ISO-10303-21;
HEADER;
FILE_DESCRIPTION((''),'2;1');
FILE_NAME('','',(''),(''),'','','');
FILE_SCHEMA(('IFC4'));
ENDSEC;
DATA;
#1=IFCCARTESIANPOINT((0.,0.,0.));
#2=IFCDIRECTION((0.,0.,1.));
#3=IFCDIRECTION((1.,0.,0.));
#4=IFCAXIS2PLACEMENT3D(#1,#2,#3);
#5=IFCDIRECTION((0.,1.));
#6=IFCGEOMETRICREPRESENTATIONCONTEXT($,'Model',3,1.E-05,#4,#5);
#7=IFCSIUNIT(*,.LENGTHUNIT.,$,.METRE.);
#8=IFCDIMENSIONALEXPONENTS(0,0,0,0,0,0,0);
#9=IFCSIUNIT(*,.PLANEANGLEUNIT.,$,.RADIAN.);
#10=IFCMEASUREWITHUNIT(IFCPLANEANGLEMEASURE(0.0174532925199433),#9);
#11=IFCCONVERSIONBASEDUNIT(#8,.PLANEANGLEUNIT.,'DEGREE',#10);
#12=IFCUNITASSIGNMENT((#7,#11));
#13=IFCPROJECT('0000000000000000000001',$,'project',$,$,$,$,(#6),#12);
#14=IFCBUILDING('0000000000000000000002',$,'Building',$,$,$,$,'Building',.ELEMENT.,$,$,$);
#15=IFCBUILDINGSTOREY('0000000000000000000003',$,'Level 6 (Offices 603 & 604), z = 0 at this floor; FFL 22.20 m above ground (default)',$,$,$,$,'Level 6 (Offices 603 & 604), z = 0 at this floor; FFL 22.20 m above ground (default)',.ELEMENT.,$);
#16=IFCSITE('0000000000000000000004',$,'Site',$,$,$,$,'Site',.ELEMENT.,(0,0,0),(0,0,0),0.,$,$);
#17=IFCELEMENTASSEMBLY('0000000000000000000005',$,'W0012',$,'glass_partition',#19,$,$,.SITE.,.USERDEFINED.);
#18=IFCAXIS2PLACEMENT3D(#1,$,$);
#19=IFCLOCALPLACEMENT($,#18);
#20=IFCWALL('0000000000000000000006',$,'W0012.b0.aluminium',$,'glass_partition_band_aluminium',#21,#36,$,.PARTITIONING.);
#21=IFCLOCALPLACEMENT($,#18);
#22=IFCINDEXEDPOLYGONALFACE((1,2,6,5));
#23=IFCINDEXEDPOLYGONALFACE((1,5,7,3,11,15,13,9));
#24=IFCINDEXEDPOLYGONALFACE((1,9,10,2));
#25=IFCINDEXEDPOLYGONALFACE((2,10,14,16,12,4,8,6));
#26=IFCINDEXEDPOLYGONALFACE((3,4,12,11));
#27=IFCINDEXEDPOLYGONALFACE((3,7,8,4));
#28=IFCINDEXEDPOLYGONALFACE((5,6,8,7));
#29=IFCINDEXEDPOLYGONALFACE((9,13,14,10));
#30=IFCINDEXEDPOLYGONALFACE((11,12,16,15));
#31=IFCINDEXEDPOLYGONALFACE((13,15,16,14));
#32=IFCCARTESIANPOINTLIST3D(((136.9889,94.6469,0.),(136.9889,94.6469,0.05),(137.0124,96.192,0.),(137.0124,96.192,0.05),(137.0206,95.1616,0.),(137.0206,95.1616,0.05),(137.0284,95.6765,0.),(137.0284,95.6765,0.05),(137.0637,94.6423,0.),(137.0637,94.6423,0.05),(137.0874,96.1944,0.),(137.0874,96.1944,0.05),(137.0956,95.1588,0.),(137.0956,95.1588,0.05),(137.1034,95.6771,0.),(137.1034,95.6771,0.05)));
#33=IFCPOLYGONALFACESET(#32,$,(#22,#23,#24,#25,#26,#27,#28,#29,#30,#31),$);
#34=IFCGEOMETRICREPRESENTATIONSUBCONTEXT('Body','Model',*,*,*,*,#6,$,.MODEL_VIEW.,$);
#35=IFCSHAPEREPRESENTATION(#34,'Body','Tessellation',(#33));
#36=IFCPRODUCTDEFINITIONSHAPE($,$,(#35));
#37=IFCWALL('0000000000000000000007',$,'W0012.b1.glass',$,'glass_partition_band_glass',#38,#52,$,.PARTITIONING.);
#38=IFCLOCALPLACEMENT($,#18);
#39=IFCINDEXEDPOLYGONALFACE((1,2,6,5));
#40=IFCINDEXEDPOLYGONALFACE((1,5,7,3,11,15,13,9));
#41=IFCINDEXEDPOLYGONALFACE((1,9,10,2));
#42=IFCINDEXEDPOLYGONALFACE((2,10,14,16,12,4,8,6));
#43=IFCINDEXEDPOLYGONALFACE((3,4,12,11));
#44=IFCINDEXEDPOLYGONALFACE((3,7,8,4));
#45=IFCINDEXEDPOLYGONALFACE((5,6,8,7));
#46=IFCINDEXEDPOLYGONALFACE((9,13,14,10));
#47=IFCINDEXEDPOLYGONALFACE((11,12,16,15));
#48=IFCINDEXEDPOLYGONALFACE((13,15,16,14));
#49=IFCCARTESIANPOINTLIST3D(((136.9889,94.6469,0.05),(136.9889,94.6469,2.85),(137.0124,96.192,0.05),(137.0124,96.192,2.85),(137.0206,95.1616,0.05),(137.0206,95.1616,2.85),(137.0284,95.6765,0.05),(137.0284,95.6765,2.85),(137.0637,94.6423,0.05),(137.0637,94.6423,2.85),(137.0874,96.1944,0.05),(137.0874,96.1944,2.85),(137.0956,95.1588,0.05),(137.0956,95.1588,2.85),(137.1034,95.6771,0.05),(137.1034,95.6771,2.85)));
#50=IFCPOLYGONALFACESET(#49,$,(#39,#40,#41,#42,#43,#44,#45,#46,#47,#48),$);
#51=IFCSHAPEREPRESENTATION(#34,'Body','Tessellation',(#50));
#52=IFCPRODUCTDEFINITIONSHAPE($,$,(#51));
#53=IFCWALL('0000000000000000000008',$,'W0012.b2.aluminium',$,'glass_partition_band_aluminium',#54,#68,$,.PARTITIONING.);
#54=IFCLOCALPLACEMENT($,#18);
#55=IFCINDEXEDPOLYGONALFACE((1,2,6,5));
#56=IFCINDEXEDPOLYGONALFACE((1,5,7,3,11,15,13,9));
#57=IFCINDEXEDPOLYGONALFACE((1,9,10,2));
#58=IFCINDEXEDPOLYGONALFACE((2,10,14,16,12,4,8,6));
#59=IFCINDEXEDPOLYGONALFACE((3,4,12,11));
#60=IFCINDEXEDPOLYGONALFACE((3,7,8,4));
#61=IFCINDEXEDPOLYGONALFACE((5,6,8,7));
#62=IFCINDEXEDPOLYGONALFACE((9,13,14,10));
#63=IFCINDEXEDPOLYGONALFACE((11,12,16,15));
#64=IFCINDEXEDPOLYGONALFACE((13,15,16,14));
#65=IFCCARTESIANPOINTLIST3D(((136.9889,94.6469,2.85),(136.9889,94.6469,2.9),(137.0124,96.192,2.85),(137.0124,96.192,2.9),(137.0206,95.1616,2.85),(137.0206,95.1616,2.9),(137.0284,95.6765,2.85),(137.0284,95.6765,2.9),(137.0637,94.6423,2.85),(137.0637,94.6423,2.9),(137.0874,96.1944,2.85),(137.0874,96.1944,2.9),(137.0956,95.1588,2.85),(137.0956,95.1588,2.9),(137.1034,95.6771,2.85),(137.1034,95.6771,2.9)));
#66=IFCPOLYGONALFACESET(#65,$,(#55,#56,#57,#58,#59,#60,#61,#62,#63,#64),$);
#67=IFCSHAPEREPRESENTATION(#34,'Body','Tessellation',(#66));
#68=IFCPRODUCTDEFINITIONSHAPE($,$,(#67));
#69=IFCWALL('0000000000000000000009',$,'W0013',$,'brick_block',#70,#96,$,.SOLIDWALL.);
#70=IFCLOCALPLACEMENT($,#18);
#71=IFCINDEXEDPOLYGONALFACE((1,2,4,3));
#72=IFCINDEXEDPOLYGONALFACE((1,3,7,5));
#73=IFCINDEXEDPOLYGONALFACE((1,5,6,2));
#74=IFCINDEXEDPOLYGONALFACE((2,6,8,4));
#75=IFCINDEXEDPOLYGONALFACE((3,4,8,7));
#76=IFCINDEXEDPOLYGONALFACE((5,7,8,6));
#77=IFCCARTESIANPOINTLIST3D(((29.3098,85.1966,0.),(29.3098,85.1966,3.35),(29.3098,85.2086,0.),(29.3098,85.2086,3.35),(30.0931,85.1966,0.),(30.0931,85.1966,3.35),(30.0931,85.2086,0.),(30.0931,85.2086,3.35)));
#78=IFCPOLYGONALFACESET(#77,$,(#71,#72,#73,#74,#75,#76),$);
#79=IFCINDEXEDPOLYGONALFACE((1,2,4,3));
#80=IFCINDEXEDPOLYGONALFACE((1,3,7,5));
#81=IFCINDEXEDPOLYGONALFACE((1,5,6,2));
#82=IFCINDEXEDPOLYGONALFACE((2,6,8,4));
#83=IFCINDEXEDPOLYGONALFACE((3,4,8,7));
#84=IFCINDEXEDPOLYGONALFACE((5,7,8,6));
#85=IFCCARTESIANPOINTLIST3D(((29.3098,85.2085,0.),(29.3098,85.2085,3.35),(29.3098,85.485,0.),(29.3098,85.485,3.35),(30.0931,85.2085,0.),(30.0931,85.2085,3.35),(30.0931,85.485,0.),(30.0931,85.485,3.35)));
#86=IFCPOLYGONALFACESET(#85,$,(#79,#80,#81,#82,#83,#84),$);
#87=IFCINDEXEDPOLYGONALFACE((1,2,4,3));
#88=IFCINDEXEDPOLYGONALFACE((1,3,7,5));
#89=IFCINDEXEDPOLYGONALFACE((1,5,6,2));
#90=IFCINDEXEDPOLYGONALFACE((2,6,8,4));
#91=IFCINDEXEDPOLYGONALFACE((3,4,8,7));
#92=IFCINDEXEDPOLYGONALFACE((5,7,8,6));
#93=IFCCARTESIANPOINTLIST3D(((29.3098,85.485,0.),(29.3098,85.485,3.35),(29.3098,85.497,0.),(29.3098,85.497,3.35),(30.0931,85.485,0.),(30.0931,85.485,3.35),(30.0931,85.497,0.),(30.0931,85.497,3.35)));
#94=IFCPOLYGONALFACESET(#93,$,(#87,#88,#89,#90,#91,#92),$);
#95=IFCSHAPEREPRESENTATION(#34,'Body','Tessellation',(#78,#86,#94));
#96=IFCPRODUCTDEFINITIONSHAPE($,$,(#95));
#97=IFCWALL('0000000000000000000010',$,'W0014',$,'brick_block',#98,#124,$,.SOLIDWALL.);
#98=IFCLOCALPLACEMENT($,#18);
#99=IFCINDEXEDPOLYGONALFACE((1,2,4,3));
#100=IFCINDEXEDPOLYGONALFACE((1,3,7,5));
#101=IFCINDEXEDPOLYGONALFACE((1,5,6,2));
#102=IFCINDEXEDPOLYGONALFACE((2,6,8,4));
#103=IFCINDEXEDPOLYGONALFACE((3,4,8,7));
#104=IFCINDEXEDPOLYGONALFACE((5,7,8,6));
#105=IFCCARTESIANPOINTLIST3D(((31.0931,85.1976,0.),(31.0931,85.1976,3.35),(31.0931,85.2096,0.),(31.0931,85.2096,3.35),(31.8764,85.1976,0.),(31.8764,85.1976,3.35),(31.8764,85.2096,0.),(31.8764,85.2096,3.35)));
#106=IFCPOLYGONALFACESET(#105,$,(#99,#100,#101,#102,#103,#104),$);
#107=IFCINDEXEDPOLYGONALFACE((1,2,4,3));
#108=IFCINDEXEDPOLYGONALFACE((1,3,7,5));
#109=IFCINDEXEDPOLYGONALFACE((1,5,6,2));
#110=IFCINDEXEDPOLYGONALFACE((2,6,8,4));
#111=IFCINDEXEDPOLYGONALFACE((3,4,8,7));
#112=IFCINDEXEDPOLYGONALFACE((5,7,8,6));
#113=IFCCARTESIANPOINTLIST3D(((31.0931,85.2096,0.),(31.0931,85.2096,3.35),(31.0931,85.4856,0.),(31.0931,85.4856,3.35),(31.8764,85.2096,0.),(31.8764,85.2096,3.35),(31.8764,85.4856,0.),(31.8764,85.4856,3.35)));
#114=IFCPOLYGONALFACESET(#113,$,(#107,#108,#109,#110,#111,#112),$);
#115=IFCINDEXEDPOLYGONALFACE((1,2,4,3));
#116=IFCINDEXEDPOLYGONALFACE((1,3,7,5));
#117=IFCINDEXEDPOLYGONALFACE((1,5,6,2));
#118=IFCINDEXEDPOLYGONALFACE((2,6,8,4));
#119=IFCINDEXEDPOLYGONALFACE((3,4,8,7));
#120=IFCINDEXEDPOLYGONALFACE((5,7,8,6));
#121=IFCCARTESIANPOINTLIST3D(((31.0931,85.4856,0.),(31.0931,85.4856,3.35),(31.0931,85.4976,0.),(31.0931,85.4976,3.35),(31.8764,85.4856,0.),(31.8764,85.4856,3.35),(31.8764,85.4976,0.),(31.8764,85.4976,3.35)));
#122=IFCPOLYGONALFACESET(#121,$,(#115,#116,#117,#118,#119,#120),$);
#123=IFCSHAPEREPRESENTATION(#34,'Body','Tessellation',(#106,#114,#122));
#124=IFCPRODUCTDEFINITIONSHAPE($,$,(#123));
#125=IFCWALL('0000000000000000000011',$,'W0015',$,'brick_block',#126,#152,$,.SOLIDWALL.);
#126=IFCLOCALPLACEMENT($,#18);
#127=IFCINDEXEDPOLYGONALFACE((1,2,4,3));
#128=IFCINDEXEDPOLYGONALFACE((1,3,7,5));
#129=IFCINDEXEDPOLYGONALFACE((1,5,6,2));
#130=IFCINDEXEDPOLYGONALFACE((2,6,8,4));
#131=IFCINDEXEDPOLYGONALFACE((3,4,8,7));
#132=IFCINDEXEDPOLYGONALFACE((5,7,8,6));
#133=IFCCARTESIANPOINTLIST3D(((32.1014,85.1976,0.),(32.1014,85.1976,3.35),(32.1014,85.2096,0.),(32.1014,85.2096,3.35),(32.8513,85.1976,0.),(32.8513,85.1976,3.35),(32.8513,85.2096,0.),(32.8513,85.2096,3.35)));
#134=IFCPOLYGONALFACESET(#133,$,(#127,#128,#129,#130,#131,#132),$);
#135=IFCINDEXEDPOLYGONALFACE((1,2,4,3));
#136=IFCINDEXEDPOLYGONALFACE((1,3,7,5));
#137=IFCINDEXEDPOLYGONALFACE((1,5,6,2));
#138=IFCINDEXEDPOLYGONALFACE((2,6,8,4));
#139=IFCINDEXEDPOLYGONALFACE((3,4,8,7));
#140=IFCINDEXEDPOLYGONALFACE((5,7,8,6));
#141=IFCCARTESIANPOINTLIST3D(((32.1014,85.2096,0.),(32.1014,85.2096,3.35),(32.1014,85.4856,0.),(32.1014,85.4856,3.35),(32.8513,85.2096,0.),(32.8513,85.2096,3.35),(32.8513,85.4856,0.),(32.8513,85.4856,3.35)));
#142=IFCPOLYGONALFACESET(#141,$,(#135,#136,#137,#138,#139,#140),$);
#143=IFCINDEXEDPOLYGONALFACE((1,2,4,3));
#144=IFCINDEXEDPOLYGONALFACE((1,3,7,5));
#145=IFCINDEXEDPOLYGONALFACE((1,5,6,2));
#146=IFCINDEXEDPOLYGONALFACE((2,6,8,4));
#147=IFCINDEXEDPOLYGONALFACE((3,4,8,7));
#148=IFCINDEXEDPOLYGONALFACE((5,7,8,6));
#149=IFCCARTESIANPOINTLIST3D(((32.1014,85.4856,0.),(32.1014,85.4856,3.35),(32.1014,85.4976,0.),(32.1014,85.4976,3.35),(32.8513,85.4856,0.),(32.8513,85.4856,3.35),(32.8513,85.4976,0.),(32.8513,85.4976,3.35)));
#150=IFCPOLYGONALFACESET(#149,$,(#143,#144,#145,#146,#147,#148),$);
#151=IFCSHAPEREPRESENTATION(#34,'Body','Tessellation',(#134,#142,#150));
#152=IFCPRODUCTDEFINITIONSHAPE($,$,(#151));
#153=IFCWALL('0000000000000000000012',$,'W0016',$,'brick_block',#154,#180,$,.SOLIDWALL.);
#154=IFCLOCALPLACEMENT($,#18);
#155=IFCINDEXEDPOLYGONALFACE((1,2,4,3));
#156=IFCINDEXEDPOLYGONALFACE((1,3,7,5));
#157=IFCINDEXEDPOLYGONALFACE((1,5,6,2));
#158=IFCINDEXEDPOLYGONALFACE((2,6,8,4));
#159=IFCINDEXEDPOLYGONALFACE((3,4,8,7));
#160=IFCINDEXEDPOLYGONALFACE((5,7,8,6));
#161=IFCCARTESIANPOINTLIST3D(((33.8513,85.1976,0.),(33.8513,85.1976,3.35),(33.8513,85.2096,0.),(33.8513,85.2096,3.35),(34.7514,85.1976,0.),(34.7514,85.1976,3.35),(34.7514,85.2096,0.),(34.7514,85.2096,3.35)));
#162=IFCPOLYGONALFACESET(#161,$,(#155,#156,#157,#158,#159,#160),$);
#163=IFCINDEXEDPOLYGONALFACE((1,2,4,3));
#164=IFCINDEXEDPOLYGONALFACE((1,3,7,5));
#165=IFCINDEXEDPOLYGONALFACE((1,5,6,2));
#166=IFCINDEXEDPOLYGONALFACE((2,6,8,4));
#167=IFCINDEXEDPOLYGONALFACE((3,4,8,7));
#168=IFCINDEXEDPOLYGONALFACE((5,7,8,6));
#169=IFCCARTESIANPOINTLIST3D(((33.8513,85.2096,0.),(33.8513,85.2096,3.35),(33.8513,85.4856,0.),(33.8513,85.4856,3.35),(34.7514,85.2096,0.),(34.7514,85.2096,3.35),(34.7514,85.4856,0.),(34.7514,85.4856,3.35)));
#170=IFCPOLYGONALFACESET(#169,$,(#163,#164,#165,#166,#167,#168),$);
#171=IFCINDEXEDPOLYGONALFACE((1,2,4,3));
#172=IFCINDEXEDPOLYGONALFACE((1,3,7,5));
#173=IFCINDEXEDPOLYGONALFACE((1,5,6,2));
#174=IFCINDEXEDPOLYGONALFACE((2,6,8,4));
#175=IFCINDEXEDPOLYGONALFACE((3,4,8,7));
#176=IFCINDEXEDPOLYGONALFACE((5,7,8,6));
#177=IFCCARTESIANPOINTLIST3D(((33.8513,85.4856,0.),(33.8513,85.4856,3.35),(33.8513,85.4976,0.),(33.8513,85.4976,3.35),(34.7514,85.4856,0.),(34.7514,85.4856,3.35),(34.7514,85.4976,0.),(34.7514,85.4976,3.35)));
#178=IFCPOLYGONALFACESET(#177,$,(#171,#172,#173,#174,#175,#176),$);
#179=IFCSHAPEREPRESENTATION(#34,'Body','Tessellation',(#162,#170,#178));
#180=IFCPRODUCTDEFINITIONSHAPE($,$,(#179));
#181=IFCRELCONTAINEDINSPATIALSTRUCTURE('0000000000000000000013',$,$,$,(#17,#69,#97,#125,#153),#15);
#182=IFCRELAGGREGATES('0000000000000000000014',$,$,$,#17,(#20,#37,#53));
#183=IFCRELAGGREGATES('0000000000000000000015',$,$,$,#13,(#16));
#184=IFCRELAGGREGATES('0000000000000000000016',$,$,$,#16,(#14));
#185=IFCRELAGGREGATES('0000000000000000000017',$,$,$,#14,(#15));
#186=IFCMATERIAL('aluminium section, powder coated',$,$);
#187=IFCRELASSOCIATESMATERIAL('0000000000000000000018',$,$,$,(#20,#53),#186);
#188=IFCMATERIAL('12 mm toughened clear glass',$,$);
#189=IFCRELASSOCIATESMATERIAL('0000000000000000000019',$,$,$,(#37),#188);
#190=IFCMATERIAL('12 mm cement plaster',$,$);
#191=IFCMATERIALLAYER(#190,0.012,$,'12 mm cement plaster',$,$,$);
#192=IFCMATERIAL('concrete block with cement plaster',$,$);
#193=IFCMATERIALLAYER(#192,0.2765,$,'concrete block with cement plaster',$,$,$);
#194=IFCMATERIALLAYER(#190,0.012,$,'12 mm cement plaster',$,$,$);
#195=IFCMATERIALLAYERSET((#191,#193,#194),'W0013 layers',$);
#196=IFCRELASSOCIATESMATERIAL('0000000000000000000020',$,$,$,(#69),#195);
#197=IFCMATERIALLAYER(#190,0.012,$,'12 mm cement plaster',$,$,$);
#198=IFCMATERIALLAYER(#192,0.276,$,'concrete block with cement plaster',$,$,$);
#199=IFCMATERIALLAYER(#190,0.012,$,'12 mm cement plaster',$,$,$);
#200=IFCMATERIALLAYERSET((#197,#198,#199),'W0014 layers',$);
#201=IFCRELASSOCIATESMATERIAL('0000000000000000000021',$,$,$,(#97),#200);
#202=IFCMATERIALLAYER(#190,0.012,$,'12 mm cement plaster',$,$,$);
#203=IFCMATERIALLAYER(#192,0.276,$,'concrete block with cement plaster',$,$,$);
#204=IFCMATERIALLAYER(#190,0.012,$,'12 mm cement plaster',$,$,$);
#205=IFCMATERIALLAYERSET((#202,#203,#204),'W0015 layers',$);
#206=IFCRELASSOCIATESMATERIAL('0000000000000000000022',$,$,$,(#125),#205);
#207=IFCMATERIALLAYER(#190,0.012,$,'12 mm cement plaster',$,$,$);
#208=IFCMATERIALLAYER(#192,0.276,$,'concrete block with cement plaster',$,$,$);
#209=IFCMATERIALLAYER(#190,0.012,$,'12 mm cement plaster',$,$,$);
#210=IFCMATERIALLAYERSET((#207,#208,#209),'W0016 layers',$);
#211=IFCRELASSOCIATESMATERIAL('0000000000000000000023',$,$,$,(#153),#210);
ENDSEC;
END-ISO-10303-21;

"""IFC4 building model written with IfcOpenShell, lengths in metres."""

from ifc_helpers import new_model, entity, si_unit, converted_unit, direction, frame, frame_2d, origin_with_axes, origin_2d_with_axis, place, context, subcontext, project, spatial, polyline, rectangle, outline, extrude, material, layer, layer_set, layer_usage, element, aggregate, save


model = new_model("IFC4")

# Units and contexts
model_context = context("Model", 3, precision=1e-05, world=origin_with_axes(), true_north=direction((0.0, 1.0)))
body_context = subcontext(model_context, "Body", "Model", "MODEL_VIEW")
ifc_project = project(units=[si_unit("LENGTHUNIT", "METRE"), converted_unit("PLANEANGLEUNIT", "DEGREE", entity("IfcPlaneAngleMeasure", 0.0174532925199433), si_unit("PLANEANGLEUNIT", "RADIAN"), dimensions=[0, 0, 0, 0, 0, 0, 0])], contexts=[model_context])

# Site, building, storey
site = spatial("IfcSite", under=ifc_project, Name="Site", LongName="Site", CompositionType="ELEMENT", RefLatitude=(0, 0, 0), RefLongitude=(0, 0, 0), RefElevation=0.0)
building = spatial("IfcBuilding", under=site, Name="Building", LongName="Building", CompositionType="ELEMENT")
storey = spatial("IfcBuildingStorey", under=building, Name="Level 6 (Offices 603 & 604), z = 0 at this floor; FFL 22.20 m above ground (default)", LongName="Level 6 (Offices 603 & 604), z = 0 at this floor; FFL 22.20 m above ground (default)", CompositionType="ELEMENT")

# Shared definitions
ifc_material_1 = material(Name="12 mm cement plaster")
ifc_material_2 = material(Name="concrete block with cement plaster")
placement = place(None, origin_with_axes())

# Element assembly, walls
assembly = element("IfcElementAssembly", 1, inside=storey, Name="W0012", ObjectType="glass_partition", AssemblyPlace="SITE", PredefinedType="USERDEFINED")
ifc_material_3 = material(Name="aluminium section, powder coated")
wall_1 = element("IfcWall", 2, at=placement, material=ifc_material_3, Name="W0012.b0.aluminium", ObjectType="glass_partition_band_aluminium", PredefinedType="PARTITIONING", context=body_context, shape_type="SweptSolid", body=[
    extrude(outline(polyline([(-0.0652, -0.7717), (-0.0334, -0.257), (-0.0257, 0.2578), (-0.0416, 0.7734), (0.0333, 0.7757), (0.0493, 0.2584), (0.0415, -0.2599), (0.0097, -0.7764), (-0.0652, -0.7717)])), frame((137.0541, 95.4187, 0.0), z_axis=(0.0, 0.0, 1.0), x_axis=(1.0, 0.0, 0.0)), (0.0, 0.0, 1.0), 0.05),
])
ifc_material_4 = material(Name="12 mm toughened clear glass")
wall_2 = element("IfcWall", 3, at=placement, material=ifc_material_4, Name="W0012.b1.glass", ObjectType="glass_partition_band_glass", PredefinedType="PARTITIONING", context=body_context, shape_type="SweptSolid", body=[
    extrude(outline(polyline([(-0.0652, -0.7717), (-0.0334, -0.257), (-0.0257, 0.2578), (-0.0416, 0.7734), (0.0333, 0.7757), (0.0493, 0.2584), (0.0415, -0.2599), (0.0097, -0.7764), (-0.0652, -0.7717)])), frame((137.0541, 95.4187, 0.05), z_axis=(0.0, 0.0, 1.0), x_axis=(1.0, 0.0, 0.0)), (0.0, 0.0, 1.0), 2.8),
])
wall_3 = element("IfcWall", 4, at=placement, material=ifc_material_3, Name="W0012.b2.aluminium", ObjectType="glass_partition_band_aluminium", PredefinedType="PARTITIONING", context=body_context, shape_type="SweptSolid", body=[
    extrude(outline(polyline([(-0.0652, -0.7717), (-0.0334, -0.257), (-0.0257, 0.2578), (-0.0416, 0.7734), (0.0333, 0.7757), (0.0493, 0.2584), (0.0415, -0.2599), (0.0097, -0.7764), (-0.0652, -0.7717)])), frame((137.0541, 95.4187, 2.85), z_axis=(0.0, 0.0, 1.0), x_axis=(1.0, 0.0, 0.0)), (0.0, 0.0, 1.0), 0.05),
])
aggregate(assembly, [wall_1, wall_2, wall_3])

# Walls
ifc_layer_1 = layer(ifc_material_1, 0.012, Name="12 mm cement plaster")
ifc_layer_2 = layer(ifc_material_2, 0.2765, Name="concrete block with cement plaster")
ifc_layer_3 = layer(ifc_material_1, 0.012, Name="12 mm cement plaster")
ifc_layer_set_1 = layer_set([ifc_layer_1, ifc_layer_2, ifc_layer_3], Name="W0013 layers")
ifc_layer_usage_1 = layer_usage(ifc_layer_set_1, "AXIS2", "POSITIVE", -0.1502)
element("IfcWall", 5, at=placement, inside=storey, material=ifc_layer_usage_1, Name="W0013", ObjectType="brick_block", PredefinedType="SOLIDWALL", context=body_context, shape_type="SweptSolid", body=[
    extrude(rectangle(XDim=0.7833, YDim=0.012, at=frame_2d((0.0, 0.0), x_axis=(1.0, 0.0))), frame((29.7015, 85.2026, 0.0), z_axis=(0.0, 0.0, 1.0), x_axis=(1.0, 0.0, 0.0)), (0.0, 0.0, 1.0), 3.35),
    extrude(rectangle(XDim=0.7833, YDim=0.2765, at=frame_2d((0.0, 0.1442), x_axis=(1.0, 0.0))), frame((29.7015, 85.2026, 0.0), z_axis=(0.0, 0.0, 1.0), x_axis=(1.0, 0.0, 0.0)), (0.0, 0.0, 1.0), 3.35),
    extrude(rectangle(XDim=0.7833, YDim=0.012, at=frame_2d((0.0, 0.2885), x_axis=(1.0, 0.0))), frame((29.7015, 85.2026, 0.0), z_axis=(0.0, 0.0, 1.0), x_axis=(1.0, 0.0, 0.0)), (0.0, 0.0, 1.0), 3.35),
])
ifc_layer_4 = layer(ifc_material_1, 0.012, Name="12 mm cement plaster")
ifc_layer_5 = layer(ifc_material_2, 0.276, Name="concrete block with cement plaster")
ifc_layer_6 = layer(ifc_material_1, 0.012, Name="12 mm cement plaster")
ifc_layer_set_2 = layer_set([ifc_layer_4, ifc_layer_5, ifc_layer_6], Name="W0014 layers")
ifc_layer_usage_2 = layer_usage(ifc_layer_set_2, "AXIS2", "POSITIVE", -0.15)
element("IfcWall", 6, at=placement, inside=storey, material=ifc_layer_usage_2, Name="W0014", ObjectType="brick_block", PredefinedType="SOLIDWALL", context=body_context, shape_type="SweptSolid", body=[
    extrude(rectangle(XDim=0.7833, YDim=0.012, at=frame_2d((0.0, 0.0), x_axis=(1.0, 0.0))), frame((31.4847, 85.2036, 0.0), z_axis=(0.0, 0.0, 1.0), x_axis=(1.0, 0.0, 0.0)), (0.0, 0.0, 1.0), 3.35),
    extrude(rectangle(XDim=0.7833, YDim=0.276, at=frame_2d((0.0, 0.144), x_axis=(1.0, 0.0))), frame((31.4847, 85.2036, 0.0), z_axis=(0.0, 0.0, 1.0), x_axis=(1.0, 0.0, 0.0)), (0.0, 0.0, 1.0), 3.35),
    extrude(rectangle(XDim=0.7833, YDim=0.012, at=frame_2d((0.0, 0.288), x_axis=(1.0, 0.0))), frame((31.4847, 85.2036, 0.0), z_axis=(0.0, 0.0, 1.0), x_axis=(1.0, 0.0, 0.0)), (0.0, 0.0, 1.0), 3.35),
])
ifc_layer_7 = layer(ifc_material_1, 0.012, Name="12 mm cement plaster")
ifc_layer_8 = layer(ifc_material_2, 0.276, Name="concrete block with cement plaster")
ifc_layer_9 = layer(ifc_material_1, 0.012, Name="12 mm cement plaster")
ifc_layer_set_3 = layer_set([ifc_layer_7, ifc_layer_8, ifc_layer_9], Name="W0015 layers")
ifc_layer_usage_3 = layer_usage(ifc_layer_set_3, "AXIS2", "POSITIVE", -0.15)
element("IfcWall", 7, at=placement, inside=storey, material=ifc_layer_usage_3, Name="W0015", ObjectType="brick_block", PredefinedType="SOLIDWALL", context=body_context, shape_type="SweptSolid", body=[
    extrude(rectangle(XDim=0.7499, YDim=0.012, at=origin_2d_with_axis()), frame((32.4763, 85.2036, 0.0), z_axis=(0.0, 0.0, 1.0), x_axis=(1.0, 0.0, 0.0)), (0.0, 0.0, 1.0), 3.35),
    extrude(rectangle(XDim=0.7499, YDim=0.276, at=frame_2d((0.0, 0.144), x_axis=(1.0, 0.0))), frame((32.4763, 85.2036, 0.0), z_axis=(0.0, 0.0, 1.0), x_axis=(1.0, 0.0, 0.0)), (0.0, 0.0, 1.0), 3.35),
    extrude(rectangle(XDim=0.7499, YDim=0.012, at=frame_2d((0.0, 0.288), x_axis=(1.0, 0.0))), frame((32.4763, 85.2036, 0.0), z_axis=(0.0, 0.0, 1.0), x_axis=(1.0, 0.0, 0.0)), (0.0, 0.0, 1.0), 3.35),
])
ifc_layer_10 = layer(ifc_material_1, 0.012, Name="12 mm cement plaster")
ifc_layer_11 = layer(ifc_material_2, 0.276, Name="concrete block with cement plaster")
ifc_layer_12 = layer(ifc_material_1, 0.012, Name="12 mm cement plaster")
ifc_layer_set_4 = layer_set([ifc_layer_10, ifc_layer_11, ifc_layer_12], Name="W0016 layers")
ifc_layer_usage_4 = layer_usage(ifc_layer_set_4, "AXIS2", "POSITIVE", -0.15)
element("IfcWall", 8, at=placement, inside=storey, material=ifc_layer_usage_4, Name="W0016", ObjectType="brick_block", PredefinedType="SOLIDWALL", context=body_context, shape_type="SweptSolid", body=[
    extrude(rectangle(XDim=0.9001, YDim=0.012, at=origin_2d_with_axis()), frame((34.3013, 85.2036, 0.0), z_axis=(0.0, 0.0, 1.0), x_axis=(1.0, 0.0, 0.0)), (0.0, 0.0, 1.0), 3.35),
    extrude(rectangle(XDim=0.9001, YDim=0.276, at=frame_2d((0.0, 0.144), x_axis=(1.0, 0.0))), frame((34.3013, 85.2036, 0.0), z_axis=(0.0, 0.0, 1.0), x_axis=(1.0, 0.0, 0.0)), (0.0, 0.0, 1.0), 3.35),
    extrude(rectangle(XDim=0.9001, YDim=0.012, at=frame_2d((0.0, 0.288), x_axis=(1.0, 0.0))), frame((34.3013, 85.2036, 0.0), z_axis=(0.0, 0.0, 1.0), x_axis=(1.0, 0.0, 0.0)), (0.0, 0.0, 1.0), 3.35),
])

save(model, "model.ifc")
